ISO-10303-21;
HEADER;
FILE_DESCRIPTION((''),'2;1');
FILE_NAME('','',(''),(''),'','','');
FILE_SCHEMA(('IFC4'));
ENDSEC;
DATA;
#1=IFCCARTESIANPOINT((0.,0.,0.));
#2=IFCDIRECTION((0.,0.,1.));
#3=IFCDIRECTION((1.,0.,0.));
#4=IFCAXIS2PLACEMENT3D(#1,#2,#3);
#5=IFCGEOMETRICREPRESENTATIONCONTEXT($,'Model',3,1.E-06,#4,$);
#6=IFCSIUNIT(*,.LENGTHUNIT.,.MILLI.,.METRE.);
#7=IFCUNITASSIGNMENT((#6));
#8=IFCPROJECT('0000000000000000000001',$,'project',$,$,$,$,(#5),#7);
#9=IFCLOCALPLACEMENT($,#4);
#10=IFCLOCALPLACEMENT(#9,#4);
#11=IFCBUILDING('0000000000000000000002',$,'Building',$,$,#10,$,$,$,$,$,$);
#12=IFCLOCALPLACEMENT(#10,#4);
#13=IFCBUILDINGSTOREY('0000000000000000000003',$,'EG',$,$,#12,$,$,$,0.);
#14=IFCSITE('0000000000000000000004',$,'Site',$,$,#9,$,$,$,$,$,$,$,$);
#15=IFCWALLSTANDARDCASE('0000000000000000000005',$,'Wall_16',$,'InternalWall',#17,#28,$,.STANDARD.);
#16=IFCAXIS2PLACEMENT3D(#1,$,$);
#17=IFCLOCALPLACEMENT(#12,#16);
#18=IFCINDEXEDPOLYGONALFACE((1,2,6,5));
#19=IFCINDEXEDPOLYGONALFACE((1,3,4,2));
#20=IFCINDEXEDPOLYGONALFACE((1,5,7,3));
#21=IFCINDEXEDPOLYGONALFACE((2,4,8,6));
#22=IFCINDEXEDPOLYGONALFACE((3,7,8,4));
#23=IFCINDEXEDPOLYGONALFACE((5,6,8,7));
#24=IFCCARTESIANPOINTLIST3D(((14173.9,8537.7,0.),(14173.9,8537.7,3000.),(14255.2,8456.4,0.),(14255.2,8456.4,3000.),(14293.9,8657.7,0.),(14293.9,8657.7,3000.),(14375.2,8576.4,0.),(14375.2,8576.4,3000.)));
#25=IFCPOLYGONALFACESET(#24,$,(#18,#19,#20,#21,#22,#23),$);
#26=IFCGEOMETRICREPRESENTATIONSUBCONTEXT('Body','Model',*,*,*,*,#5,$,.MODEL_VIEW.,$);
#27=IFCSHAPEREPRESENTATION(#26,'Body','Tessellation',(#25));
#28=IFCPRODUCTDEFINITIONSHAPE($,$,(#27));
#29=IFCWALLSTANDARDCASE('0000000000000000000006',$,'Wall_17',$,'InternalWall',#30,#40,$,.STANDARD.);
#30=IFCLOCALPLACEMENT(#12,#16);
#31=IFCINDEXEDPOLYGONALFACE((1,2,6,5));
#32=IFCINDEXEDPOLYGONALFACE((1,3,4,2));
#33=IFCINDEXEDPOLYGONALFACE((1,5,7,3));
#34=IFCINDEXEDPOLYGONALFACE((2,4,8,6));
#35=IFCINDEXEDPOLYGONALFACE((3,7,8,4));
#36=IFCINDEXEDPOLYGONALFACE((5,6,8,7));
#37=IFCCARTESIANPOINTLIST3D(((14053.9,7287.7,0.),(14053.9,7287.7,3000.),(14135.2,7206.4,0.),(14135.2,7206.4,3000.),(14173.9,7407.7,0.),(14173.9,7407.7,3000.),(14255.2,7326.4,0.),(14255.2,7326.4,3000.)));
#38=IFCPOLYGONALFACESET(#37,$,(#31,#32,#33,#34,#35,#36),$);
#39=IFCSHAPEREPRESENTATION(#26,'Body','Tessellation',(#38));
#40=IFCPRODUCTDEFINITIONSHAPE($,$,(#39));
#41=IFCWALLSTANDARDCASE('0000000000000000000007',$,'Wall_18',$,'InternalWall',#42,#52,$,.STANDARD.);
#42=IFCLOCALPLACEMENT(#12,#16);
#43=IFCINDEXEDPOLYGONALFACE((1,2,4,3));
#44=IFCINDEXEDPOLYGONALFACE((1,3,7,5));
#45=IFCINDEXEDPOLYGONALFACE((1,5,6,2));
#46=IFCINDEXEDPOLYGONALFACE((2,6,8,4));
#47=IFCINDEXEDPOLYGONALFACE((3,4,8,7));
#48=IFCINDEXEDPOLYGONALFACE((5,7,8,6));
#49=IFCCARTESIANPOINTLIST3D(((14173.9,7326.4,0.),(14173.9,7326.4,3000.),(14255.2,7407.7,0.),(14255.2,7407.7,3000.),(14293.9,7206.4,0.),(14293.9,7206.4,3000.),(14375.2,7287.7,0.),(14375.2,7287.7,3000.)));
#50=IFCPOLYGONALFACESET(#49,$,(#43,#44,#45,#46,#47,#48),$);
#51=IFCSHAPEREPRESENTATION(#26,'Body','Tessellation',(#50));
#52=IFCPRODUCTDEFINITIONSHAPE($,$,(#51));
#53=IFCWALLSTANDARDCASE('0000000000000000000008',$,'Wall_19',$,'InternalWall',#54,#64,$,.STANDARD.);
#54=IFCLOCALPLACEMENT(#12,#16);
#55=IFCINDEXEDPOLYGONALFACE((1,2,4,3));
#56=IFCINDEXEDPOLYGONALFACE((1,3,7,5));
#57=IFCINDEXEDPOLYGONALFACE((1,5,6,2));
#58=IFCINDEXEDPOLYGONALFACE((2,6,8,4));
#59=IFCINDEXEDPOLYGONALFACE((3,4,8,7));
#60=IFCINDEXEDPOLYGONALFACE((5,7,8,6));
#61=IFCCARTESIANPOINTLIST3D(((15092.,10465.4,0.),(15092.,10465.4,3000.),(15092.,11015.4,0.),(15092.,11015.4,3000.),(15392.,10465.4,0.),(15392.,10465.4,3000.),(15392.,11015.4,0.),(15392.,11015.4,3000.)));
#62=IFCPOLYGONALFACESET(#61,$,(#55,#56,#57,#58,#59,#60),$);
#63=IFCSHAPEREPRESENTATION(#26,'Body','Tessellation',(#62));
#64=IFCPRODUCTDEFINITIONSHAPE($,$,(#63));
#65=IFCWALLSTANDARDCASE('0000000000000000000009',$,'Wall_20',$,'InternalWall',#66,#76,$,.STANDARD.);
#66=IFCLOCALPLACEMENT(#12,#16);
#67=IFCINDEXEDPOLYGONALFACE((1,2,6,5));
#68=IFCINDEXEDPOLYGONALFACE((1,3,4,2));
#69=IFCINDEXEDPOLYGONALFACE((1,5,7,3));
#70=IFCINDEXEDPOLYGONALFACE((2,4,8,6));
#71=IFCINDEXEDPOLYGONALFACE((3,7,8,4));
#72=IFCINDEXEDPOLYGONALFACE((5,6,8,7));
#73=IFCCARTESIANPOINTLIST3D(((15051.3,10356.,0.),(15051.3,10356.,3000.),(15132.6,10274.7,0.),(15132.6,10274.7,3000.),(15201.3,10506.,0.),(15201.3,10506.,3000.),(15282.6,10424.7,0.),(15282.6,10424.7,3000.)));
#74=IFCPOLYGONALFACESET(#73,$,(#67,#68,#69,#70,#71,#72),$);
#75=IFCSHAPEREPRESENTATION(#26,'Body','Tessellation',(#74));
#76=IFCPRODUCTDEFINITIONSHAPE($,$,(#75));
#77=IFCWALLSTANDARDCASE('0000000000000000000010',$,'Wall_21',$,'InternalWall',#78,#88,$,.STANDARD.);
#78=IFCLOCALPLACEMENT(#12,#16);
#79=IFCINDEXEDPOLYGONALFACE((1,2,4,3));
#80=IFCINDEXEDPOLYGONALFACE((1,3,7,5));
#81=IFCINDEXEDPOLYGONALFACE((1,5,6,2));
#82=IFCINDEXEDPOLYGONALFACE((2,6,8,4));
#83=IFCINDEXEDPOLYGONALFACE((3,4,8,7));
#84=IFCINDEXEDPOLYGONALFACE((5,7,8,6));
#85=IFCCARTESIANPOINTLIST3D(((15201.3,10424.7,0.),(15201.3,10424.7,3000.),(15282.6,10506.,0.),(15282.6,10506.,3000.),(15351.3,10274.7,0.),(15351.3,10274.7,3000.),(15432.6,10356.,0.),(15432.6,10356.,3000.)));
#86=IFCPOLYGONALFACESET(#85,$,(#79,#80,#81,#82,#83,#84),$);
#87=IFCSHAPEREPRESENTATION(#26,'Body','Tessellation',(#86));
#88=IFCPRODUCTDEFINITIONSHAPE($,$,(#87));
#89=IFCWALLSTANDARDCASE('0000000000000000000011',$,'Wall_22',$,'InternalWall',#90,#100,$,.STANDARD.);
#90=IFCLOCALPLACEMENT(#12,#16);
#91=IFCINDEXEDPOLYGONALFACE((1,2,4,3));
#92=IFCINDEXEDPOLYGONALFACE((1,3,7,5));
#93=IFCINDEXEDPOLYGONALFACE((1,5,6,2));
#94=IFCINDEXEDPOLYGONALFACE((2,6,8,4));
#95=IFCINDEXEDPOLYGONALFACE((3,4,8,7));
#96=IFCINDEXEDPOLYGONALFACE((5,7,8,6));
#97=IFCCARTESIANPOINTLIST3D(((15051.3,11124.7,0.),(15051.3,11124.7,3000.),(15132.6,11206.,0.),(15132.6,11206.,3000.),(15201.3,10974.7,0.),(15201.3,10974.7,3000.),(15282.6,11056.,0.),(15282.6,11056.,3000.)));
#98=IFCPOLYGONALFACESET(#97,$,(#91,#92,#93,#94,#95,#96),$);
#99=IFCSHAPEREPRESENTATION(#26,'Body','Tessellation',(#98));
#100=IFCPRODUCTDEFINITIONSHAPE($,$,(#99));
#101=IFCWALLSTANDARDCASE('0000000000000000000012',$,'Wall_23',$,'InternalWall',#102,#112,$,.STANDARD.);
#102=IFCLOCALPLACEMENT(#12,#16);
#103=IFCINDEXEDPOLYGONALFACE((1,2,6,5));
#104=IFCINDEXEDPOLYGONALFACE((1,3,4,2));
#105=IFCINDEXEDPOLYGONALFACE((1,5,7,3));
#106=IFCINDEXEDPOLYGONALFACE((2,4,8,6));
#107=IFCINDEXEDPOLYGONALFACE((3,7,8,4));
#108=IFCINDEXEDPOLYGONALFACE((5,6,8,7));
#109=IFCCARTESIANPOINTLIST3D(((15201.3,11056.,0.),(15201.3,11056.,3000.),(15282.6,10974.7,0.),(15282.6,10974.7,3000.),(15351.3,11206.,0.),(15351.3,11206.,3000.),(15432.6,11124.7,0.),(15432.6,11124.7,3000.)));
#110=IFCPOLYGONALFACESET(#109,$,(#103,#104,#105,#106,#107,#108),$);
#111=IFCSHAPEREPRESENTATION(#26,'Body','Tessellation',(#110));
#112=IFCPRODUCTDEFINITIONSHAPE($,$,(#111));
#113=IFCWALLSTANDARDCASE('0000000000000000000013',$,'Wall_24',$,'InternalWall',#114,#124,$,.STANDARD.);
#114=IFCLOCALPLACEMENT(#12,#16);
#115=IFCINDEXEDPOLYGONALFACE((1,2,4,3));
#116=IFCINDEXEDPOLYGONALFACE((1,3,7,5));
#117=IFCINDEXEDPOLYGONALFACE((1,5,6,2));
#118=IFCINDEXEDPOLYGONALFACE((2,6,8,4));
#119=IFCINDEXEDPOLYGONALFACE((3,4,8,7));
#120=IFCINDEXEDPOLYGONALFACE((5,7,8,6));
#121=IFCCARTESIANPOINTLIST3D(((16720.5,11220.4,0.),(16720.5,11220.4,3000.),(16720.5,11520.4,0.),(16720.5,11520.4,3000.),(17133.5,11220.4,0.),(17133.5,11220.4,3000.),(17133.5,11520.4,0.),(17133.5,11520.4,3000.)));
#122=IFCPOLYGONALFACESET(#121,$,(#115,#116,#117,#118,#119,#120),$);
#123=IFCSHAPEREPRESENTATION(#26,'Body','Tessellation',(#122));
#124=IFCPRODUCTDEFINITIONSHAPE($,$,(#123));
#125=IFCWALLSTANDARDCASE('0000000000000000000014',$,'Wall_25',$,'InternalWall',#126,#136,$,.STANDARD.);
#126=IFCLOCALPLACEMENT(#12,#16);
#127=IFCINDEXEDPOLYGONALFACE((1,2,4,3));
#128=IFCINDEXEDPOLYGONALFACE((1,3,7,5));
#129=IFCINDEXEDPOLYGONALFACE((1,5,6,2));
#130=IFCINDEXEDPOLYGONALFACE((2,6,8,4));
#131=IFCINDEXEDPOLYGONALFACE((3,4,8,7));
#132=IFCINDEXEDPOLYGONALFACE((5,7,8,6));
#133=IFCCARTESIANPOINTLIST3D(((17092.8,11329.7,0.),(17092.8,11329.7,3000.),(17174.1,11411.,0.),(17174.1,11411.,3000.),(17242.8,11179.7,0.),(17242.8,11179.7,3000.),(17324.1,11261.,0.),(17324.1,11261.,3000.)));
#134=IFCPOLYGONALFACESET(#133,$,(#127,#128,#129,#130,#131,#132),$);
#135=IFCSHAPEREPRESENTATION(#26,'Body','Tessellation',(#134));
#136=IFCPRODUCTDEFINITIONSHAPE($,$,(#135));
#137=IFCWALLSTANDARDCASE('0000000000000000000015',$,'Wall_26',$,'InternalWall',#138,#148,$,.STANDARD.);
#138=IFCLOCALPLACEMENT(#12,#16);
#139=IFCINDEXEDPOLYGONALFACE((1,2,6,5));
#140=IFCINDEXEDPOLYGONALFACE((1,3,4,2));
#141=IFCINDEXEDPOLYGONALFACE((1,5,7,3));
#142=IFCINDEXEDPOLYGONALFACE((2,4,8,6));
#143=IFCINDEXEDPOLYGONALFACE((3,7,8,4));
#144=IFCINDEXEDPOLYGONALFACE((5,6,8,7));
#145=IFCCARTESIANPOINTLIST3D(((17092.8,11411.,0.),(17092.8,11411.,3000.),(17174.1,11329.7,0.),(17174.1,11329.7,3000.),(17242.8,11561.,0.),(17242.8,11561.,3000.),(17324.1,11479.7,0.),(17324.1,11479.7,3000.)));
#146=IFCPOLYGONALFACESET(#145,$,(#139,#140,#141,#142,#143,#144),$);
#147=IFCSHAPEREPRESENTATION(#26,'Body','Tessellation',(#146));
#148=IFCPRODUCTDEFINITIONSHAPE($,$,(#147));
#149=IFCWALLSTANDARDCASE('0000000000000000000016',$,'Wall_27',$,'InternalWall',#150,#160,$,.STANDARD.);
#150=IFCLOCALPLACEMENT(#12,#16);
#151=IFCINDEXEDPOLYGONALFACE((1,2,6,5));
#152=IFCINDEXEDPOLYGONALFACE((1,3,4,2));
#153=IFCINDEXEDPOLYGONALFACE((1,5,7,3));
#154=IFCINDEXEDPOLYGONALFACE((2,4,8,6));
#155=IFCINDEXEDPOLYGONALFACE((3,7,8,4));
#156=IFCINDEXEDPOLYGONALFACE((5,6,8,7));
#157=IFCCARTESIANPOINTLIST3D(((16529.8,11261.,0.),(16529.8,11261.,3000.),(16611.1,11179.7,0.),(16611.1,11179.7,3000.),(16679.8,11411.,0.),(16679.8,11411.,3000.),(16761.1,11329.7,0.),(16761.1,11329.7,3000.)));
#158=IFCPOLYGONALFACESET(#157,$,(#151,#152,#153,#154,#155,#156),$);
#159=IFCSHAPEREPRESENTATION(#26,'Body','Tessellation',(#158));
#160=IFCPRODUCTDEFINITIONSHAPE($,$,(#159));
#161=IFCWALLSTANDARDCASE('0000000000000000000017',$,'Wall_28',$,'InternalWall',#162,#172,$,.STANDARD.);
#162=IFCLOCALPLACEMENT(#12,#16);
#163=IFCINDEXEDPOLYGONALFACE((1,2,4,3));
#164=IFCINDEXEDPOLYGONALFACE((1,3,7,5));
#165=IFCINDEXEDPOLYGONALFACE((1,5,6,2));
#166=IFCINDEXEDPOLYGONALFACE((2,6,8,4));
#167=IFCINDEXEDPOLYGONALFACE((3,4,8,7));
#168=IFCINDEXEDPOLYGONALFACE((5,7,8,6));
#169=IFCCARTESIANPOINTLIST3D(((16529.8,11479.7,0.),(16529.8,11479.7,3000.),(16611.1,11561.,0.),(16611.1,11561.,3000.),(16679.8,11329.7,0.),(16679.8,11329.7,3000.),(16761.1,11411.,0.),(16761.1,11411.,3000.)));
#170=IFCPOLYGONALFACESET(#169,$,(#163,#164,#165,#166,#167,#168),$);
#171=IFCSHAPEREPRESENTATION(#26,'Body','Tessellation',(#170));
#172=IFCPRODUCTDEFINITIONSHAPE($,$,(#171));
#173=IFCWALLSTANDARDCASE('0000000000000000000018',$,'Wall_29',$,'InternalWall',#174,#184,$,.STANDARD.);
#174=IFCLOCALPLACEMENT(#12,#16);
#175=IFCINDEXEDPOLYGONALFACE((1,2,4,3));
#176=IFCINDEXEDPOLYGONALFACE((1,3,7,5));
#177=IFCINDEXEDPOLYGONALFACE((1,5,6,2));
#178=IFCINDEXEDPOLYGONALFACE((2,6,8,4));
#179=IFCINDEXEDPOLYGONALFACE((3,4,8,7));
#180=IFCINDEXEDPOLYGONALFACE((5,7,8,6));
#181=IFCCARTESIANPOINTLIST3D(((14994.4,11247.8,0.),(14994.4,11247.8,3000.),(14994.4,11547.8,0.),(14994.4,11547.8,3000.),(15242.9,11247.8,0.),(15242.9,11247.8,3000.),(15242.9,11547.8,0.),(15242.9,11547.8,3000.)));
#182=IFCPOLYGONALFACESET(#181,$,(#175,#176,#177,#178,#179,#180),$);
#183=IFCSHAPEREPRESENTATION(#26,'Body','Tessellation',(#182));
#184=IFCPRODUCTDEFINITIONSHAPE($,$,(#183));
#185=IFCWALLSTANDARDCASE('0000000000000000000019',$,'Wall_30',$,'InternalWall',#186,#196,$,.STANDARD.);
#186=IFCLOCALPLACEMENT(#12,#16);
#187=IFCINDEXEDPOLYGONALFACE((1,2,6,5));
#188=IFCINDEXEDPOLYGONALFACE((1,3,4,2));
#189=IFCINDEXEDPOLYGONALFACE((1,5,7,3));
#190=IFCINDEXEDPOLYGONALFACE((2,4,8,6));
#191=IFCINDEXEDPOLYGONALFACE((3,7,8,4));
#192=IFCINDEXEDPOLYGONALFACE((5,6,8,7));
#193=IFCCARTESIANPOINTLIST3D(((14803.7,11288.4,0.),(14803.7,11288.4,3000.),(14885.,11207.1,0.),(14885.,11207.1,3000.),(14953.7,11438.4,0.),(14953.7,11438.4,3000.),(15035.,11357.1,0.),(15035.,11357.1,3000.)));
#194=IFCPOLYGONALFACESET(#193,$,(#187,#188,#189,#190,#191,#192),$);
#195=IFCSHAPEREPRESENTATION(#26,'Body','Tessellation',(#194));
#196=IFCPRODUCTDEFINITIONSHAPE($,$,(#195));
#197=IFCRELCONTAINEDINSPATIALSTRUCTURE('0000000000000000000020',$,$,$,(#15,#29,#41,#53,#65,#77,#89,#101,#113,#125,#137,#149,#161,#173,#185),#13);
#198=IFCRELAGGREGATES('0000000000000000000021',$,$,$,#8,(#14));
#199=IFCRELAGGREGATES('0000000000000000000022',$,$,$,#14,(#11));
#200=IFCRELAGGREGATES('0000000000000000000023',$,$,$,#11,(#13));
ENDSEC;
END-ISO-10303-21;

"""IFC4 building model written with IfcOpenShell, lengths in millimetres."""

from ifc_helpers import new_model, si_unit, frame, origin_with_axes, place, context, subcontext, project, spatial, rectangle, extrude, element, save


model = new_model("IFC4")

# Units and contexts
model_context = context("Model", 3, precision=1e-06, world=origin_with_axes())
body_context = subcontext(model_context, "Body", "Model", "MODEL_VIEW")
ifc_project = project(units=[si_unit("LENGTHUNIT", "METRE", prefix="MILLI")], contexts=[model_context])

# Site, building, storey
site_placement = place(None, origin_with_axes())
site = spatial("IfcSite", under=ifc_project, at=site_placement, Name="Site")
building_placement = place(site_placement, origin_with_axes())
building = spatial("IfcBuilding", under=site, at=building_placement, Name="Building")
storey_placement = place(building_placement, origin_with_axes())
storey = spatial("IfcBuildingStorey", under=building, at=storey_placement, Name="EG", Elevation=0.0)

# Walls
wall_1_placement = place(storey_placement, origin_with_axes())
element("IfcWallStandardCase", 1, at=wall_1_placement, inside=storey, Name="Wall_16", ObjectType="InternalWall", PredefinedType="STANDARD", context=body_context, shape_type="SweptSolid", body=[
    extrude(rectangle(XDim=169.7, YDim=115.0), frame((14274.6, 8557.1, 0.0), z_axis=(0.0, 0.0, 1.0), x_axis=(0.707107, 0.707107, 0.0)), (0.0, 0.0, 1.0), 3000.0),
])
wall_2_placement = place(storey_placement, origin_with_axes())
element("IfcWallStandardCase", 2, at=wall_2_placement, inside=storey, Name="Wall_17", ObjectType="InternalWall", PredefinedType="STANDARD", context=body_context, shape_type="SweptSolid", body=[
    extrude(rectangle(XDim=169.7, YDim=115.0), frame((14154.6, 7307.1, 0.0), z_axis=(0.0, 0.0, 1.0), x_axis=(-0.707107, -0.707107, 0.0)), (0.0, 0.0, 1.0), 3000.0),
])
wall_3_placement = place(storey_placement, origin_with_axes())
element("IfcWallStandardCase", 3, at=wall_3_placement, inside=storey, Name="Wall_18", ObjectType="InternalWall", PredefinedType="STANDARD", context=body_context, shape_type="SweptSolid", body=[
    extrude(rectangle(XDim=169.7, YDim=115.0), frame((14274.6, 7307.1, 0.0), z_axis=(0.0, 0.0, 1.0), x_axis=(0.707107, -0.707107, 0.0)), (0.0, 0.0, 1.0), 3000.0),
])
wall_4_placement = place(storey_placement, origin_with_axes())
element("IfcWallStandardCase", 4, at=wall_4_placement, inside=storey, Name="Wall_19", ObjectType="InternalWall", PredefinedType="STANDARD", context=body_context, shape_type="SweptSolid", body=[
    extrude(rectangle(XDim=550.0, YDim=300.0), frame((15242.0, 10740.4, 0.0), z_axis=(0.0, 0.0, 1.0), x_axis=(0.0, 1.0, 0.0)), (0.0, 0.0, 1.0), 3000.0),
])
wall_5_placement = place(storey_placement, origin_with_axes())
element("IfcWallStandardCase", 5, at=wall_5_placement, inside=storey, Name="Wall_20", ObjectType="InternalWall", PredefinedType="STANDARD", context=body_context, shape_type="SweptSolid", body=[
    extrude(rectangle(XDim=212.1, YDim=115.0), frame((15167.0, 10390.4, 0.0), z_axis=(0.0, 0.0, 1.0), x_axis=(-0.707107, -0.707107, 0.0)), (0.0, 0.0, 1.0), 3000.0),
])
wall_6_placement = place(storey_placement, origin_with_axes())
element("IfcWallStandardCase", 6, at=wall_6_placement, inside=storey, Name="Wall_21", ObjectType="InternalWall", PredefinedType="STANDARD", context=body_context, shape_type="SweptSolid", body=[
    extrude(rectangle(XDim=212.1, YDim=115.0), frame((15317.0, 10390.4, 0.0), z_axis=(0.0, 0.0, 1.0), x_axis=(0.707107, -0.707107, 0.0)), (0.0, 0.0, 1.0), 3000.0),
])
wall_7_placement = place(storey_placement, origin_with_axes())
element("IfcWallStandardCase", 7, at=wall_7_placement, inside=storey, Name="Wall_22", ObjectType="InternalWall", PredefinedType="STANDARD", context=body_context, shape_type="SweptSolid", body=[
    extrude(rectangle(XDim=212.1, YDim=115.0), frame((15167.0, 11090.4, 0.0), z_axis=(0.0, 0.0, 1.0), x_axis=(-0.707107, 0.707107, 0.0)), (0.0, 0.0, 1.0), 3000.0),
])
wall_8_placement = place(storey_placement, origin_with_axes())
element("IfcWallStandardCase", 8, at=wall_8_placement, inside=storey, Name="Wall_23", ObjectType="InternalWall", PredefinedType="STANDARD", context=body_context, shape_type="SweptSolid", body=[
    extrude(rectangle(XDim=212.1, YDim=115.0), frame((15317.0, 11090.4, 0.0), z_axis=(0.0, 0.0, 1.0), x_axis=(0.707107, 0.707107, 0.0)), (0.0, 0.0, 1.0), 3000.0),
])
wall_9_placement = place(storey_placement, origin_with_axes())
element("IfcWallStandardCase", 9, at=wall_9_placement, inside=storey, Name="Wall_24", ObjectType="InternalWall", PredefinedType="STANDARD", context=body_context, shape_type="SweptSolid", body=[
    extrude(rectangle(XDim=413.0, YDim=300.0), frame((16927.0, 11370.4, 0.0), z_axis=(0.0, 0.0, 1.0), x_axis=(-1.0, 0.0, 0.0)), (0.0, 0.0, 1.0), 3000.0),
])
wall_10_placement = place(storey_placement, origin_with_axes())
element("IfcWallStandardCase", 10, at=wall_10_placement, inside=storey, Name="Wall_25", ObjectType="InternalWall", PredefinedType="STANDARD", context=body_context, shape_type="SweptSolid", body=[
    extrude(rectangle(XDim=212.1, YDim=115.0), frame((17208.5, 11295.4, 0.0), z_axis=(0.0, 0.0, 1.0), x_axis=(0.707107, -0.707107, 0.0)), (0.0, 0.0, 1.0), 3000.0),
])
wall_11_placement = place(storey_placement, origin_with_axes())
element("IfcWallStandardCase", 11, at=wall_11_placement, inside=storey, Name="Wall_26", ObjectType="InternalWall", PredefinedType="STANDARD", context=body_context, shape_type="SweptSolid", body=[
    extrude(rectangle(XDim=212.1, YDim=115.0), frame((17208.5, 11445.4, 0.0), z_axis=(0.0, 0.0, 1.0), x_axis=(0.707107, 0.707107, 0.0)), (0.0, 0.0, 1.0), 3000.0),
])
wall_12_placement = place(storey_placement, origin_with_axes())
element("IfcWallStandardCase", 12, at=wall_12_placement, inside=storey, Name="Wall_27", ObjectType="InternalWall", PredefinedType="STANDARD", context=body_context, shape_type="SweptSolid", body=[
    extrude(rectangle(XDim=212.1, YDim=115.0), frame((16645.5, 11295.4, 0.0), z_axis=(0.0, 0.0, 1.0), x_axis=(-0.707107, -0.707107, 0.0)), (0.0, 0.0, 1.0), 3000.0),
])
wall_13_placement = place(storey_placement, origin_with_axes())
element("IfcWallStandardCase", 13, at=wall_13_placement, inside=storey, Name="Wall_28", ObjectType="InternalWall", PredefinedType="STANDARD", context=body_context, shape_type="SweptSolid", body=[
    extrude(rectangle(XDim=212.1, YDim=115.0), frame((16645.5, 11445.4, 0.0), z_axis=(0.0, 0.0, 1.0), x_axis=(-0.707107, 0.707107, 0.0)), (0.0, 0.0, 1.0), 3000.0),
])
wall_14_placement = place(storey_placement, origin_with_axes())
element("IfcWallStandardCase", 14, at=wall_14_placement, inside=storey, Name="Wall_29", ObjectType="InternalWall", PredefinedType="STANDARD", context=body_context, shape_type="SweptSolid", body=[
    extrude(rectangle(XDim=248.5, YDim=300.0), frame((15118.6, 11397.8, 0.0), z_axis=(0.0, 0.0, 1.0), x_axis=(1.0, 0.0, 0.0)), (0.0, 0.0, 1.0), 3000.0),
])
wall_15_placement = place(storey_placement, origin_with_axes())
element("IfcWallStandardCase", 15, at=wall_15_placement, inside=storey, Name="Wall_30", ObjectType="InternalWall", PredefinedType="STANDARD", context=body_context, shape_type="SweptSolid", body=[
    extrude(rectangle(XDim=212.1, YDim=115.0), frame((14919.4, 11322.8, 0.0), z_axis=(0.0, 0.0, 1.0), x_axis=(-0.707107, -0.707107, 0.0)), (0.0, 0.0, 1.0), 3000.0),
])

save(model, "model.ifc")
